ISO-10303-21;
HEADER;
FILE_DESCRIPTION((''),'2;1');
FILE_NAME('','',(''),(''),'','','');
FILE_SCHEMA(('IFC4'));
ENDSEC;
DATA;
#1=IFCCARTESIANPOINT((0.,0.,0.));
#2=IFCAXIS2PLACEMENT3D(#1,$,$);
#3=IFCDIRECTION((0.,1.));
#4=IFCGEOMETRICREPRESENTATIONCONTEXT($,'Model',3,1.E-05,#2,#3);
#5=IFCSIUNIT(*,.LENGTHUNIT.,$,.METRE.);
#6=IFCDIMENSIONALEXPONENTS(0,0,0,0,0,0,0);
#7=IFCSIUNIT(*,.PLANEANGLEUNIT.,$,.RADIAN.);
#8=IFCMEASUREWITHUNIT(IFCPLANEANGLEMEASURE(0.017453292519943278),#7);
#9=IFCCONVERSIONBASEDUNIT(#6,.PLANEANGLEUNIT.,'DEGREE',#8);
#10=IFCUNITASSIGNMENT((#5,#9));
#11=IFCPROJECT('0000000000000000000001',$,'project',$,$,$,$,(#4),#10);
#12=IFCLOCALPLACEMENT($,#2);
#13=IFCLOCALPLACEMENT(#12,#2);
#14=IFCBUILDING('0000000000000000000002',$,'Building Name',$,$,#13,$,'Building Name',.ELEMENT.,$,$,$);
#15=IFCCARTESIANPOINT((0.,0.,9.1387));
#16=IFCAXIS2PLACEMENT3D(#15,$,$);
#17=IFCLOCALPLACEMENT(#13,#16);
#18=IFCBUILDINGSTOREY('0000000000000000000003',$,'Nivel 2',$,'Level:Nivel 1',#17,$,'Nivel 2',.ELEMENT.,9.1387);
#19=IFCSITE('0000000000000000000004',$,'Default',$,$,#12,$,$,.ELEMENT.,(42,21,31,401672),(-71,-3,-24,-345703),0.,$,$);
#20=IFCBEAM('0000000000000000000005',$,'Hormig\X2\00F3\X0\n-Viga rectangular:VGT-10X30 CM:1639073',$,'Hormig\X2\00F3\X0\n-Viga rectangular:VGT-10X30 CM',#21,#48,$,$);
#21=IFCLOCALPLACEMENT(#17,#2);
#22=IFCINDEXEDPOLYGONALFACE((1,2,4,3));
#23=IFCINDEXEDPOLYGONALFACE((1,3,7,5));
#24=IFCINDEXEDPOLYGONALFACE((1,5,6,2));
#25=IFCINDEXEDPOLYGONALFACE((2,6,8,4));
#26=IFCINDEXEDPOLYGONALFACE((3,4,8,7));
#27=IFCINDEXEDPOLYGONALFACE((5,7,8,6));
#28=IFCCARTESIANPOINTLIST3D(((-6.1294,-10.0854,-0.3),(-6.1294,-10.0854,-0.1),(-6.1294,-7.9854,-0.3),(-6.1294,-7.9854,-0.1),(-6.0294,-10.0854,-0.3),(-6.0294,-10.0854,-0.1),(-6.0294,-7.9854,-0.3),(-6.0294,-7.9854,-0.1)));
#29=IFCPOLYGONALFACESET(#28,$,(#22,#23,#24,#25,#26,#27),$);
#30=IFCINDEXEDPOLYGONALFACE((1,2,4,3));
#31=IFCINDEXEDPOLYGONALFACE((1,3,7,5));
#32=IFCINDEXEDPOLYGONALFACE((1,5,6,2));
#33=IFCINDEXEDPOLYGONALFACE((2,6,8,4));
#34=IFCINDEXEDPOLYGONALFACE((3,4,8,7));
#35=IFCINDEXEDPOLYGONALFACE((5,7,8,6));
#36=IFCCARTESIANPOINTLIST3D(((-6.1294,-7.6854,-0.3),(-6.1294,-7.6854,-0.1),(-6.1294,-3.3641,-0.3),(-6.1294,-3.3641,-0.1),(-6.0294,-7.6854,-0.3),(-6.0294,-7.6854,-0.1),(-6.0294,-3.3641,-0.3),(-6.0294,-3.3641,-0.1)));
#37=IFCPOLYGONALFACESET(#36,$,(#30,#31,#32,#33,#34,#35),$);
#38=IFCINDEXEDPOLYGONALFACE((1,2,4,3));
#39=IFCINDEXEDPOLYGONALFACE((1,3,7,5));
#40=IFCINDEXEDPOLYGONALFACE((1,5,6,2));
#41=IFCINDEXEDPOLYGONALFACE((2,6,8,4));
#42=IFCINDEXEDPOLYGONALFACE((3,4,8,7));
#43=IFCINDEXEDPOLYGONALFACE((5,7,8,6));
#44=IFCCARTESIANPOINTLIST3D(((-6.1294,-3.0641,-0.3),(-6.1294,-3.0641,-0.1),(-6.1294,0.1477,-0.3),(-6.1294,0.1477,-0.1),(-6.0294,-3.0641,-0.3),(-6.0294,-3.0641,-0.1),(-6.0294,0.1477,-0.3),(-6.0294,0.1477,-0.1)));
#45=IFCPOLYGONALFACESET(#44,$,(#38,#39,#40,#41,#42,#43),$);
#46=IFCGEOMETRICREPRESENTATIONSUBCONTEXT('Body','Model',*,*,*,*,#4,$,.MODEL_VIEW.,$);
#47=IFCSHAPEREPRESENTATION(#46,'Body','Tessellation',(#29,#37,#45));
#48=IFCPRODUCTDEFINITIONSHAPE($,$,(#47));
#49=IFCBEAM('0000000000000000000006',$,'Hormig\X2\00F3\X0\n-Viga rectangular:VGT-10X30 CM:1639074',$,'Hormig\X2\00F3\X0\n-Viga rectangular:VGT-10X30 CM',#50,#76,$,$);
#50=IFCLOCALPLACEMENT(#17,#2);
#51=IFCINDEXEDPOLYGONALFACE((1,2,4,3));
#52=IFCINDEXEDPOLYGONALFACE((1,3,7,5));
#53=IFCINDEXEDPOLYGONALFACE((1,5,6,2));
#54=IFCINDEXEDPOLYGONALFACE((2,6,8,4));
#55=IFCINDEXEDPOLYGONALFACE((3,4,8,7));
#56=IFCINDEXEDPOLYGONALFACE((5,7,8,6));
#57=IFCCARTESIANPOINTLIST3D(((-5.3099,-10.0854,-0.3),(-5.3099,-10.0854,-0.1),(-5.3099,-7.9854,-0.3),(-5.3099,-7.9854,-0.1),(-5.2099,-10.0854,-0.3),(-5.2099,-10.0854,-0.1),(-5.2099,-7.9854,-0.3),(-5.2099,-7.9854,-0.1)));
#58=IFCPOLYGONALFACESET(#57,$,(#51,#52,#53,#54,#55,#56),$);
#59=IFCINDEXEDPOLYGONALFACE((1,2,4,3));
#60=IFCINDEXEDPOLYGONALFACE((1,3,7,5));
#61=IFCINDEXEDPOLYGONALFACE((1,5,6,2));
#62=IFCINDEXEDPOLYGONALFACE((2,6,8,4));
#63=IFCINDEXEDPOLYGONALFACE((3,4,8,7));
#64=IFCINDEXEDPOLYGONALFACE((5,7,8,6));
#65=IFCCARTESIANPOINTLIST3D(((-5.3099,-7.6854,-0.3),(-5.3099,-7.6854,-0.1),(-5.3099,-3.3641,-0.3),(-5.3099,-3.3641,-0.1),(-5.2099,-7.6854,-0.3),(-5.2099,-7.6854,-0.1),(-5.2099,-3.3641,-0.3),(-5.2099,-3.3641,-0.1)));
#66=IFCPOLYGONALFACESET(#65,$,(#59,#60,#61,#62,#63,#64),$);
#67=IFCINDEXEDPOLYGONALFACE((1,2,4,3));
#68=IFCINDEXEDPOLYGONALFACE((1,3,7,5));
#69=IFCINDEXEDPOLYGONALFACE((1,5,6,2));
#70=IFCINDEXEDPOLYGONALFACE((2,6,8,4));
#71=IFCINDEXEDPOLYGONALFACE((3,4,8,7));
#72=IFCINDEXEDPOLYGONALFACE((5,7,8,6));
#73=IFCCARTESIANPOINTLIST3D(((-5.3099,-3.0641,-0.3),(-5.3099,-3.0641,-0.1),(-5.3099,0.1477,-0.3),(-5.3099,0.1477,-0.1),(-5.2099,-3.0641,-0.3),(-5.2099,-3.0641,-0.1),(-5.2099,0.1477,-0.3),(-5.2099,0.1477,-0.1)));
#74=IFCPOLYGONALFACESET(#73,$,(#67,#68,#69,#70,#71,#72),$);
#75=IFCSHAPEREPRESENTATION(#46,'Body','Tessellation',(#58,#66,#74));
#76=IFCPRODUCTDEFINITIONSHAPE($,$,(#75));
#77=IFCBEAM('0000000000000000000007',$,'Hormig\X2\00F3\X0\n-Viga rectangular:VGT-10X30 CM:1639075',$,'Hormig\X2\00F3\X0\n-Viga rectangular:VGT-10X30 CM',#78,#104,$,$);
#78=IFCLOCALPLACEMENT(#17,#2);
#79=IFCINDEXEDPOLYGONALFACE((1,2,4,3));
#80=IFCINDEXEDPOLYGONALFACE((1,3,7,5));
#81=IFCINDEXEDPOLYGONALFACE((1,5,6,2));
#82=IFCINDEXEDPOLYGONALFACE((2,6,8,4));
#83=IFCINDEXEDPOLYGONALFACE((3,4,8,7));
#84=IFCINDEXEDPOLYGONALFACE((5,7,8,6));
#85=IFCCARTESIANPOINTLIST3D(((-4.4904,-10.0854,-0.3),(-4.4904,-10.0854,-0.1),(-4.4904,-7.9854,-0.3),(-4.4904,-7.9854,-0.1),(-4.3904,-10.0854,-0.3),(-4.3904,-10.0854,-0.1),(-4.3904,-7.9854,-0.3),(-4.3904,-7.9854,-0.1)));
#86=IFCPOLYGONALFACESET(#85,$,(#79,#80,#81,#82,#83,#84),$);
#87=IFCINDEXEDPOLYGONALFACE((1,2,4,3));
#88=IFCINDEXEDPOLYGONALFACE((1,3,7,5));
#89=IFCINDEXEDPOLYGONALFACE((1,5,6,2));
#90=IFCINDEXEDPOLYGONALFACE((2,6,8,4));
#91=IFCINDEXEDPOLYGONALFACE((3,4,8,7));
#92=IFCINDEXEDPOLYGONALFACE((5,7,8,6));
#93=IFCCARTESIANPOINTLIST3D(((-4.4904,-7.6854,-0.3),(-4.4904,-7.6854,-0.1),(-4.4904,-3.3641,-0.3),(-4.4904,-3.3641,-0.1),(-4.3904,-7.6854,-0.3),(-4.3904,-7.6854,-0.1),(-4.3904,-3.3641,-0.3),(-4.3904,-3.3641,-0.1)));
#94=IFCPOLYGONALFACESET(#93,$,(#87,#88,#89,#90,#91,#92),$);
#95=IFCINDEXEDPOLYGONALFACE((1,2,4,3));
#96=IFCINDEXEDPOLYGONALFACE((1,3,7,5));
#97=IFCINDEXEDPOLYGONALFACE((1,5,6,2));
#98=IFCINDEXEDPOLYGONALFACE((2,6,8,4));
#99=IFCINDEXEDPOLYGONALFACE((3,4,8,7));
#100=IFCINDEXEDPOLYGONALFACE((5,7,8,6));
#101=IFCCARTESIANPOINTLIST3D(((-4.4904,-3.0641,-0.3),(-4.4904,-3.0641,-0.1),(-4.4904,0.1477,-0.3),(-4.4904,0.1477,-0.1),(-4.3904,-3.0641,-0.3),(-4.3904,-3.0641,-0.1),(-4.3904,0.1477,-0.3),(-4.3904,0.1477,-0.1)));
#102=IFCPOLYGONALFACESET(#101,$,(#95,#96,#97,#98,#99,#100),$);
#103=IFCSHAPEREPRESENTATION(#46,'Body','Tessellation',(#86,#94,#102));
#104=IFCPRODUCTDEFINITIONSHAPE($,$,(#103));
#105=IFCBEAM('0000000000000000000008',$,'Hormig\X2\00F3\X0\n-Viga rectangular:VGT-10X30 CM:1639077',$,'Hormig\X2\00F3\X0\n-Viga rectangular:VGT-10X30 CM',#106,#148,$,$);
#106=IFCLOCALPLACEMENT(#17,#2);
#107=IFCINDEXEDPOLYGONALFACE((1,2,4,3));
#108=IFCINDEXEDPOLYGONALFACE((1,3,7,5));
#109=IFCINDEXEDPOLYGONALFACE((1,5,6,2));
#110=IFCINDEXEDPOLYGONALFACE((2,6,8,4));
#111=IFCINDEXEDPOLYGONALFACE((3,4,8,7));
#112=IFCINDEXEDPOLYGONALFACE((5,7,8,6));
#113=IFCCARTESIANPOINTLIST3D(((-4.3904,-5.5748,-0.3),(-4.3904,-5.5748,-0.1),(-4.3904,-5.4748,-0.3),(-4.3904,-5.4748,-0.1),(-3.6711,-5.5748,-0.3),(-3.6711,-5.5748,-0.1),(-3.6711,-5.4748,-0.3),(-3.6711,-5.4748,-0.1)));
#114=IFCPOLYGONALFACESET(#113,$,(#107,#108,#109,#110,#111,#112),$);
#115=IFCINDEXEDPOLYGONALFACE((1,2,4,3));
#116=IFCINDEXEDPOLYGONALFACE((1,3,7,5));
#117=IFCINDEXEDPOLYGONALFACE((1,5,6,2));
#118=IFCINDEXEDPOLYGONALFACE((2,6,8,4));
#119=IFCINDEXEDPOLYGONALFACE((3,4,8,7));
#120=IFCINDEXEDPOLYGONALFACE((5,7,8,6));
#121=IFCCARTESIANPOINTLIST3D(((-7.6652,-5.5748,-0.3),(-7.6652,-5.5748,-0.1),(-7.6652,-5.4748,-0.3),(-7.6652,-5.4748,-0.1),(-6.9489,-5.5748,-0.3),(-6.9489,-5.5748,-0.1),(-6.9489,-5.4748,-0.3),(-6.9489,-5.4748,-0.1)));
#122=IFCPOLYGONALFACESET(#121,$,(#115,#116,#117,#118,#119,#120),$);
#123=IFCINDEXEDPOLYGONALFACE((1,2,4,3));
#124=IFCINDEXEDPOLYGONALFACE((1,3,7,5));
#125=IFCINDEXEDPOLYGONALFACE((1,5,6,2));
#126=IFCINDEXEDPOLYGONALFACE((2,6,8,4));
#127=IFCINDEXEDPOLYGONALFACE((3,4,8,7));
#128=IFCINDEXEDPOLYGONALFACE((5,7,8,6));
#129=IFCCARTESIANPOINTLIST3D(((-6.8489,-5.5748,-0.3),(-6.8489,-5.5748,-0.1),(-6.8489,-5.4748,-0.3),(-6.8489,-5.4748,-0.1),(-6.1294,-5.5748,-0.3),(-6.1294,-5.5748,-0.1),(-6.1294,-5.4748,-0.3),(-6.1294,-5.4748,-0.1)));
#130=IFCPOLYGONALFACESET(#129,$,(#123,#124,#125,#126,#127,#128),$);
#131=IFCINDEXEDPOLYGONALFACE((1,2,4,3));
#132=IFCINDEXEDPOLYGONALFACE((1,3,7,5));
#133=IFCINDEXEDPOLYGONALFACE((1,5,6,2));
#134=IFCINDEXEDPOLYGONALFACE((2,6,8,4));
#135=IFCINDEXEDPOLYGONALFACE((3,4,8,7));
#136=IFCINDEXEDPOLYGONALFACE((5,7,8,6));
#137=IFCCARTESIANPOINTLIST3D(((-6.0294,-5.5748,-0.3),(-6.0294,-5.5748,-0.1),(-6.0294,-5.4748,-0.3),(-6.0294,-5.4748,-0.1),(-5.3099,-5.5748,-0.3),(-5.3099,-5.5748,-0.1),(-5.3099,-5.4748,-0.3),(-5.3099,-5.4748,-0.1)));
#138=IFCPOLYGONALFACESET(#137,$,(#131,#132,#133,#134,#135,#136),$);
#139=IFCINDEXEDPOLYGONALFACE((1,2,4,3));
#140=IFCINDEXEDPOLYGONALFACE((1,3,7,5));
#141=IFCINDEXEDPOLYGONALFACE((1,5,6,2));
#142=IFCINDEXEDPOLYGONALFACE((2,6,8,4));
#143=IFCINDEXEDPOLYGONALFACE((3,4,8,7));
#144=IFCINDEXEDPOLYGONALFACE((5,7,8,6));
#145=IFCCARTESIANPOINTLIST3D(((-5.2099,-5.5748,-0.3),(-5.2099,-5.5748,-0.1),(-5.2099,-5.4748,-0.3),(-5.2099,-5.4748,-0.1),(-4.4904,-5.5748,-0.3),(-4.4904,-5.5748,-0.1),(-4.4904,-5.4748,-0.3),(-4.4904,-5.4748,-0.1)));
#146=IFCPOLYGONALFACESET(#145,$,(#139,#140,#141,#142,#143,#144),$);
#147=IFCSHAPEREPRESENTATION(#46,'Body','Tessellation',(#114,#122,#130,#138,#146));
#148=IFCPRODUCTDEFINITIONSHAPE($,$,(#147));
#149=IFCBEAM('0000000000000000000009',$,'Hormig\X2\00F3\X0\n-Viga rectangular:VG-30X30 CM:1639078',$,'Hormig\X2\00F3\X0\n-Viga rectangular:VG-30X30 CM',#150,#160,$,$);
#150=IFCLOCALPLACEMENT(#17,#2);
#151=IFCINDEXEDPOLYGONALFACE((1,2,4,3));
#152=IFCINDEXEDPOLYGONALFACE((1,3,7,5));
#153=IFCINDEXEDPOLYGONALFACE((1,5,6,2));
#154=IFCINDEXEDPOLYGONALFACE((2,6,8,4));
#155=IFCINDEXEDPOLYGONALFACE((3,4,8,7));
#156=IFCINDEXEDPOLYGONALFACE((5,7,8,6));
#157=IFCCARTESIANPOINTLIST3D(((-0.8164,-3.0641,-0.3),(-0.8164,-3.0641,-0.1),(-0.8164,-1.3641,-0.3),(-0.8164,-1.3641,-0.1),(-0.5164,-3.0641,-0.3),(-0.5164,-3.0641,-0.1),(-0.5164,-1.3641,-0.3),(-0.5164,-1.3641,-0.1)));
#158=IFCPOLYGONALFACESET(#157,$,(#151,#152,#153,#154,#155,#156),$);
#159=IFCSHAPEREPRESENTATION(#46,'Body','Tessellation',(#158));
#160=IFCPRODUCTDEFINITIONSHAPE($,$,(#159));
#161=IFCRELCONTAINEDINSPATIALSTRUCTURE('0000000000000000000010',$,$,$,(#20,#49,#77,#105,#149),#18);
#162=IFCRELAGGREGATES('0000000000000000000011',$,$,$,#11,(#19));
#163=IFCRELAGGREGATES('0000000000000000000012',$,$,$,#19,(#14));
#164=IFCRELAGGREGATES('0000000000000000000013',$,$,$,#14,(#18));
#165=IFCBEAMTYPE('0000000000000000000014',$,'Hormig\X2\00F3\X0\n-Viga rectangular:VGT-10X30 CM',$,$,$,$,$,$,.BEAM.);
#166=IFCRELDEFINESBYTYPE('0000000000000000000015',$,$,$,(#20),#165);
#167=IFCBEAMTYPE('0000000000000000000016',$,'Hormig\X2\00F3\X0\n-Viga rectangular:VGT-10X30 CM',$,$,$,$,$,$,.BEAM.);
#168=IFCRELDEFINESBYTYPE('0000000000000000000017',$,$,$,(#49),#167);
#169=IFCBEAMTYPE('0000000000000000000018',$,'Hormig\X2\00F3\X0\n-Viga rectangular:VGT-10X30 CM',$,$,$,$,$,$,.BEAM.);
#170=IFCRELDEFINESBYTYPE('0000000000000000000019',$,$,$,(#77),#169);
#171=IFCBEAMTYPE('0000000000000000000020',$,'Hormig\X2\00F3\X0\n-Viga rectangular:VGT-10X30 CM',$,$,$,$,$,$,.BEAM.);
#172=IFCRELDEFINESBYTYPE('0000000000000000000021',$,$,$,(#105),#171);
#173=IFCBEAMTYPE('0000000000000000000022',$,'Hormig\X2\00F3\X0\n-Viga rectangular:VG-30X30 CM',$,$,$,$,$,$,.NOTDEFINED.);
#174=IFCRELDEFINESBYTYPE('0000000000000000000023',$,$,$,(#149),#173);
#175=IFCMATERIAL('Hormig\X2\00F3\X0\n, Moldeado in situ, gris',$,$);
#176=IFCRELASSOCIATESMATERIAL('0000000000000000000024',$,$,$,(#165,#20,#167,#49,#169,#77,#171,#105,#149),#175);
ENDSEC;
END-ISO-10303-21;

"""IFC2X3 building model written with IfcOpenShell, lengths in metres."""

from ifc_helpers import new_model, entity, si_unit, converted_unit, direction, frame, frame_2d, origin, place, context, subcontext, project, spatial, rectangle, extrude, source, transform, mapped, material, type_object, type_shapes, element, save


model = new_model("IFC2X3")

# Units and contexts
model_context = context("Model", 3, precision=1e-05, world=origin(), true_north=direction((0.0, 1.0)))
body_context = subcontext(model_context, "Body", "Model", "MODEL_VIEW")
ifc_project = project(units=[si_unit("LENGTHUNIT", "METRE"), converted_unit("PLANEANGLEUNIT", "DEGREE", entity("IfcPlaneAngleMeasure", 0.017453292519943278), si_unit("PLANEANGLEUNIT", "RADIAN"), dimensions=[0, 0, 0, 0, 0, 0, 0])], contexts=[model_context])

# Site, building, storey
site_placement = place(None, origin())
site = spatial("IfcSite", under=ifc_project, at=site_placement, Name="Default", CompositionType="ELEMENT", RefLatitude=(42, 21, 31, 401672), RefLongitude=(-71, -3, -24, -345703), RefElevation=0.0)
building_placement = place(site_placement, origin())
building = spatial("IfcBuilding", under=site, at=building_placement, Name="Building Name", LongName="Building Name", CompositionType="ELEMENT")
storey_placement = place(building_placement, frame((0.0, 0.0, 9.1387)))
storey = spatial("IfcBuildingStorey", under=building, at=storey_placement, Name="Nivel 2", ObjectType="Level:Nivel 1", LongName="Nivel 2", CompositionType="ELEMENT", Elevation=9.1387)

# Beams
ifc_material = material(Name="Hormigón, Moldeado in situ, gris")
beam_type_1 = type_object("IfcBeamType", Name="Hormigón-Viga rectangular:VGT-10X30 CM", PredefinedType="BEAM", material=ifc_material)
shared_shape_1 = source(origin(), body_context, "Body", "SweptSolid", [
    extrude(rectangle(XDim=0.2, YDim=0.1, at=frame_2d((0.0, 0.0), x_axis=(0.0, 1.0))), frame((-6.0794, -7.9854, 8.9387), z_axis=(0.0, -1.0, 0.0), x_axis=(-1.0, 0.0, 0.0)), (0.0, 0.0, 1.0), 2.1),
    extrude(rectangle(XDim=0.2, YDim=0.1, at=frame_2d((0.0, 0.0), x_axis=(0.0, 1.0))), frame((-6.0794, -3.3641, 8.9387), z_axis=(0.0, -1.0, 0.0), x_axis=(-1.0, 0.0, 0.0)), (0.0, 0.0, 1.0), 4.3214),
    extrude(rectangle(XDim=0.2, YDim=0.1, at=frame_2d((0.0, 0.0), x_axis=(0.0, 1.0))), frame((-6.0794, 0.1477, 8.9387), z_axis=(0.0, -1.0, 0.0), x_axis=(-1.0, 0.0, 0.0)), (0.0, 0.0, 1.0), 3.2118),
])
type_shapes(beam_type_1, [shared_shape_1])
beam_1_placement = place(storey_placement, frame((0.0, 0.0, -9.1387)))
element("IfcBeam", 1, at=beam_1_placement, inside=storey, type_object=beam_type_1, material=ifc_material, Name="Hormigón-Viga rectangular:VGT-10X30 CM:1639073", ObjectType="Hormigón-Viga rectangular:VGT-10X30 CM", context=body_context, shape_type="MappedRepresentation", body=[
    mapped(shared_shape_1, transform((0.0, 0.0, 0.0), scale=1.0)),
])
beam_type_2 = type_object("IfcBeamType", Name="Hormigón-Viga rectangular:VGT-10X30 CM", PredefinedType="BEAM", material=ifc_material)
shared_shape_2 = source(origin(), body_context, "Body", "SweptSolid", [
    extrude(rectangle(XDim=0.2, YDim=0.1, at=frame_2d((0.0, 0.0), x_axis=(0.0, 1.0))), frame((-5.2599, -7.9854, 8.9387), z_axis=(0.0, -1.0, 0.0), x_axis=(-1.0, 0.0, 0.0)), (0.0, 0.0, 1.0), 2.1),
    extrude(rectangle(XDim=0.2, YDim=0.1, at=frame_2d((0.0, 0.0), x_axis=(0.0, 1.0))), frame((-5.2599, -3.3641, 8.9387), z_axis=(0.0, -1.0, 0.0), x_axis=(-1.0, 0.0, 0.0)), (0.0, 0.0, 1.0), 4.3214),
    extrude(rectangle(XDim=0.2, YDim=0.1, at=frame_2d((0.0, 0.0), x_axis=(0.0, 1.0))), frame((-5.2599, 0.1477, 8.9387), z_axis=(0.0, -1.0, 0.0), x_axis=(-1.0, 0.0, 0.0)), (0.0, 0.0, 1.0), 3.2118),
])
type_shapes(beam_type_2, [shared_shape_2])
beam_2_placement = place(storey_placement, frame((0.0, 0.0, -9.1387)))
element("IfcBeam", 2, at=beam_2_placement, inside=storey, type_object=beam_type_2, material=ifc_material, Name="Hormigón-Viga rectangular:VGT-10X30 CM:1639074", ObjectType="Hormigón-Viga rectangular:VGT-10X30 CM", context=body_context, shape_type="MappedRepresentation", body=[
    mapped(shared_shape_2, transform((0.0, 0.0, 0.0), scale=1.0)),
])
beam_type_3 = type_object("IfcBeamType", Name="Hormigón-Viga rectangular:VGT-10X30 CM", PredefinedType="BEAM", material=ifc_material)
shared_shape_3 = source(origin(), body_context, "Body", "SweptSolid", [
    extrude(rectangle(XDim=0.2, YDim=0.1, at=frame_2d((0.0, 0.0), x_axis=(0.0, 1.0))), frame((-4.4404, -7.9854, 8.9387), z_axis=(0.0, -1.0, 0.0), x_axis=(-1.0, 0.0, 0.0)), (0.0, 0.0, 1.0), 2.1),
    extrude(rectangle(XDim=0.2, YDim=0.1, at=frame_2d((0.0, 0.0), x_axis=(0.0, 1.0))), frame((-4.4404, -3.3641, 8.9387), z_axis=(0.0, -1.0, 0.0), x_axis=(-1.0, 0.0, 0.0)), (0.0, 0.0, 1.0), 4.3214),
    extrude(rectangle(XDim=0.2, YDim=0.1, at=frame_2d((0.0, 0.0), x_axis=(0.0, 1.0))), frame((-4.4404, 0.1477, 8.9387), z_axis=(0.0, -1.0, 0.0), x_axis=(-1.0, 0.0, 0.0)), (0.0, 0.0, 1.0), 3.2118),
])
type_shapes(beam_type_3, [shared_shape_3])
beam_3_placement = place(storey_placement, frame((0.0, 0.0, -9.1387)))
element("IfcBeam", 3, at=beam_3_placement, inside=storey, type_object=beam_type_3, material=ifc_material, Name="Hormigón-Viga rectangular:VGT-10X30 CM:1639075", ObjectType="Hormigón-Viga rectangular:VGT-10X30 CM", context=body_context, shape_type="MappedRepresentation", body=[
    mapped(shared_shape_3, transform((0.0, 0.0, 0.0), scale=1.0)),
])
beam_type_4 = type_object("IfcBeamType", Name="Hormigón-Viga rectangular:VGT-10X30 CM", PredefinedType="BEAM", material=ifc_material)
shared_shape_4 = source(origin(), body_context, "Body", "SweptSolid", [
    extrude(rectangle(XDim=0.2, YDim=0.1, at=frame_2d((0.0, 0.0), x_axis=(1.0, 0.0))), frame((-4.3904, -5.5248, 8.9387), z_axis=(1.0, 0.0, 0.0), x_axis=(0.0, 0.0, -1.0)), (0.0, 0.0, 1.0), 0.7194),
    extrude(rectangle(XDim=0.2, YDim=0.1, at=frame_2d((0.0, 0.0), x_axis=(1.0, 0.0))), frame((-7.6652, -5.5248, 8.9387), z_axis=(1.0, 0.0, 0.0), x_axis=(0.0, 0.0, -1.0)), (0.0, 0.0, 1.0), 0.7163),
    extrude(rectangle(XDim=0.2, YDim=0.1, at=frame_2d((0.0, 0.0), x_axis=(1.0, 0.0))), frame((-6.8489, -5.5248, 8.9387), z_axis=(1.0, 0.0, 0.0), x_axis=(0.0, 0.0, -1.0)), (0.0, 0.0, 1.0), 0.7195),
    extrude(rectangle(XDim=0.2, YDim=0.1, at=frame_2d((0.0, 0.0), x_axis=(1.0, 0.0))), frame((-6.0294, -5.5248, 8.9387), z_axis=(1.0, 0.0, 0.0), x_axis=(0.0, 0.0, -1.0)), (0.0, 0.0, 1.0), 0.7195),
    extrude(rectangle(XDim=0.2, YDim=0.1, at=frame_2d((0.0, 0.0), x_axis=(1.0, 0.0))), frame((-5.2099, -5.5248, 8.9387), z_axis=(1.0, 0.0, 0.0), x_axis=(0.0, 0.0, -1.0)), (0.0, 0.0, 1.0), 0.7195),
])
type_shapes(beam_type_4, [shared_shape_4])
beam_4_placement = place(storey_placement, frame((0.0, 0.0, -9.1387)))
element("IfcBeam", 4, at=beam_4_placement, inside=storey, type_object=beam_type_4, material=ifc_material, Name="Hormigón-Viga rectangular:VGT-10X30 CM:1639077", ObjectType="Hormigón-Viga rectangular:VGT-10X30 CM", context=body_context, shape_type="MappedRepresentation", body=[
    mapped(shared_shape_4, transform((0.0, 0.0, 0.0), scale=1.0)),
])
beam_type_5 = type_object("IfcBeamType", Name="Hormigón-Viga rectangular:VG-30X30 CM", PredefinedType="NOTDEFINED")
beam_5_placement = place(storey_placement, frame((-0.6664, -3.2141, 0.0), z_axis=(0.0, 0.0, 1.0), x_axis=(0.0, 1.0, 0.0)))
element("IfcBeam", 5, at=beam_5_placement, inside=storey, type_object=beam_type_5, material=ifc_material, Name="Hormigón-Viga rectangular:VG-30X30 CM:1639078", ObjectType="Hormigón-Viga rectangular:VG-30X30 CM", context=body_context, shape_type="SweptSolid", body=[
    extrude(rectangle(XDim=0.2, YDim=0.3, at=frame_2d((0.0, 0.0), x_axis=(1.0, 0.0))), frame((0.15, 0.0, -0.2), z_axis=(1.0, 0.0, 0.0), x_axis=(0.0, 0.0, -1.0)), (0.0, 0.0, 1.0), 1.7),
])

save(model, "model.ifc")
